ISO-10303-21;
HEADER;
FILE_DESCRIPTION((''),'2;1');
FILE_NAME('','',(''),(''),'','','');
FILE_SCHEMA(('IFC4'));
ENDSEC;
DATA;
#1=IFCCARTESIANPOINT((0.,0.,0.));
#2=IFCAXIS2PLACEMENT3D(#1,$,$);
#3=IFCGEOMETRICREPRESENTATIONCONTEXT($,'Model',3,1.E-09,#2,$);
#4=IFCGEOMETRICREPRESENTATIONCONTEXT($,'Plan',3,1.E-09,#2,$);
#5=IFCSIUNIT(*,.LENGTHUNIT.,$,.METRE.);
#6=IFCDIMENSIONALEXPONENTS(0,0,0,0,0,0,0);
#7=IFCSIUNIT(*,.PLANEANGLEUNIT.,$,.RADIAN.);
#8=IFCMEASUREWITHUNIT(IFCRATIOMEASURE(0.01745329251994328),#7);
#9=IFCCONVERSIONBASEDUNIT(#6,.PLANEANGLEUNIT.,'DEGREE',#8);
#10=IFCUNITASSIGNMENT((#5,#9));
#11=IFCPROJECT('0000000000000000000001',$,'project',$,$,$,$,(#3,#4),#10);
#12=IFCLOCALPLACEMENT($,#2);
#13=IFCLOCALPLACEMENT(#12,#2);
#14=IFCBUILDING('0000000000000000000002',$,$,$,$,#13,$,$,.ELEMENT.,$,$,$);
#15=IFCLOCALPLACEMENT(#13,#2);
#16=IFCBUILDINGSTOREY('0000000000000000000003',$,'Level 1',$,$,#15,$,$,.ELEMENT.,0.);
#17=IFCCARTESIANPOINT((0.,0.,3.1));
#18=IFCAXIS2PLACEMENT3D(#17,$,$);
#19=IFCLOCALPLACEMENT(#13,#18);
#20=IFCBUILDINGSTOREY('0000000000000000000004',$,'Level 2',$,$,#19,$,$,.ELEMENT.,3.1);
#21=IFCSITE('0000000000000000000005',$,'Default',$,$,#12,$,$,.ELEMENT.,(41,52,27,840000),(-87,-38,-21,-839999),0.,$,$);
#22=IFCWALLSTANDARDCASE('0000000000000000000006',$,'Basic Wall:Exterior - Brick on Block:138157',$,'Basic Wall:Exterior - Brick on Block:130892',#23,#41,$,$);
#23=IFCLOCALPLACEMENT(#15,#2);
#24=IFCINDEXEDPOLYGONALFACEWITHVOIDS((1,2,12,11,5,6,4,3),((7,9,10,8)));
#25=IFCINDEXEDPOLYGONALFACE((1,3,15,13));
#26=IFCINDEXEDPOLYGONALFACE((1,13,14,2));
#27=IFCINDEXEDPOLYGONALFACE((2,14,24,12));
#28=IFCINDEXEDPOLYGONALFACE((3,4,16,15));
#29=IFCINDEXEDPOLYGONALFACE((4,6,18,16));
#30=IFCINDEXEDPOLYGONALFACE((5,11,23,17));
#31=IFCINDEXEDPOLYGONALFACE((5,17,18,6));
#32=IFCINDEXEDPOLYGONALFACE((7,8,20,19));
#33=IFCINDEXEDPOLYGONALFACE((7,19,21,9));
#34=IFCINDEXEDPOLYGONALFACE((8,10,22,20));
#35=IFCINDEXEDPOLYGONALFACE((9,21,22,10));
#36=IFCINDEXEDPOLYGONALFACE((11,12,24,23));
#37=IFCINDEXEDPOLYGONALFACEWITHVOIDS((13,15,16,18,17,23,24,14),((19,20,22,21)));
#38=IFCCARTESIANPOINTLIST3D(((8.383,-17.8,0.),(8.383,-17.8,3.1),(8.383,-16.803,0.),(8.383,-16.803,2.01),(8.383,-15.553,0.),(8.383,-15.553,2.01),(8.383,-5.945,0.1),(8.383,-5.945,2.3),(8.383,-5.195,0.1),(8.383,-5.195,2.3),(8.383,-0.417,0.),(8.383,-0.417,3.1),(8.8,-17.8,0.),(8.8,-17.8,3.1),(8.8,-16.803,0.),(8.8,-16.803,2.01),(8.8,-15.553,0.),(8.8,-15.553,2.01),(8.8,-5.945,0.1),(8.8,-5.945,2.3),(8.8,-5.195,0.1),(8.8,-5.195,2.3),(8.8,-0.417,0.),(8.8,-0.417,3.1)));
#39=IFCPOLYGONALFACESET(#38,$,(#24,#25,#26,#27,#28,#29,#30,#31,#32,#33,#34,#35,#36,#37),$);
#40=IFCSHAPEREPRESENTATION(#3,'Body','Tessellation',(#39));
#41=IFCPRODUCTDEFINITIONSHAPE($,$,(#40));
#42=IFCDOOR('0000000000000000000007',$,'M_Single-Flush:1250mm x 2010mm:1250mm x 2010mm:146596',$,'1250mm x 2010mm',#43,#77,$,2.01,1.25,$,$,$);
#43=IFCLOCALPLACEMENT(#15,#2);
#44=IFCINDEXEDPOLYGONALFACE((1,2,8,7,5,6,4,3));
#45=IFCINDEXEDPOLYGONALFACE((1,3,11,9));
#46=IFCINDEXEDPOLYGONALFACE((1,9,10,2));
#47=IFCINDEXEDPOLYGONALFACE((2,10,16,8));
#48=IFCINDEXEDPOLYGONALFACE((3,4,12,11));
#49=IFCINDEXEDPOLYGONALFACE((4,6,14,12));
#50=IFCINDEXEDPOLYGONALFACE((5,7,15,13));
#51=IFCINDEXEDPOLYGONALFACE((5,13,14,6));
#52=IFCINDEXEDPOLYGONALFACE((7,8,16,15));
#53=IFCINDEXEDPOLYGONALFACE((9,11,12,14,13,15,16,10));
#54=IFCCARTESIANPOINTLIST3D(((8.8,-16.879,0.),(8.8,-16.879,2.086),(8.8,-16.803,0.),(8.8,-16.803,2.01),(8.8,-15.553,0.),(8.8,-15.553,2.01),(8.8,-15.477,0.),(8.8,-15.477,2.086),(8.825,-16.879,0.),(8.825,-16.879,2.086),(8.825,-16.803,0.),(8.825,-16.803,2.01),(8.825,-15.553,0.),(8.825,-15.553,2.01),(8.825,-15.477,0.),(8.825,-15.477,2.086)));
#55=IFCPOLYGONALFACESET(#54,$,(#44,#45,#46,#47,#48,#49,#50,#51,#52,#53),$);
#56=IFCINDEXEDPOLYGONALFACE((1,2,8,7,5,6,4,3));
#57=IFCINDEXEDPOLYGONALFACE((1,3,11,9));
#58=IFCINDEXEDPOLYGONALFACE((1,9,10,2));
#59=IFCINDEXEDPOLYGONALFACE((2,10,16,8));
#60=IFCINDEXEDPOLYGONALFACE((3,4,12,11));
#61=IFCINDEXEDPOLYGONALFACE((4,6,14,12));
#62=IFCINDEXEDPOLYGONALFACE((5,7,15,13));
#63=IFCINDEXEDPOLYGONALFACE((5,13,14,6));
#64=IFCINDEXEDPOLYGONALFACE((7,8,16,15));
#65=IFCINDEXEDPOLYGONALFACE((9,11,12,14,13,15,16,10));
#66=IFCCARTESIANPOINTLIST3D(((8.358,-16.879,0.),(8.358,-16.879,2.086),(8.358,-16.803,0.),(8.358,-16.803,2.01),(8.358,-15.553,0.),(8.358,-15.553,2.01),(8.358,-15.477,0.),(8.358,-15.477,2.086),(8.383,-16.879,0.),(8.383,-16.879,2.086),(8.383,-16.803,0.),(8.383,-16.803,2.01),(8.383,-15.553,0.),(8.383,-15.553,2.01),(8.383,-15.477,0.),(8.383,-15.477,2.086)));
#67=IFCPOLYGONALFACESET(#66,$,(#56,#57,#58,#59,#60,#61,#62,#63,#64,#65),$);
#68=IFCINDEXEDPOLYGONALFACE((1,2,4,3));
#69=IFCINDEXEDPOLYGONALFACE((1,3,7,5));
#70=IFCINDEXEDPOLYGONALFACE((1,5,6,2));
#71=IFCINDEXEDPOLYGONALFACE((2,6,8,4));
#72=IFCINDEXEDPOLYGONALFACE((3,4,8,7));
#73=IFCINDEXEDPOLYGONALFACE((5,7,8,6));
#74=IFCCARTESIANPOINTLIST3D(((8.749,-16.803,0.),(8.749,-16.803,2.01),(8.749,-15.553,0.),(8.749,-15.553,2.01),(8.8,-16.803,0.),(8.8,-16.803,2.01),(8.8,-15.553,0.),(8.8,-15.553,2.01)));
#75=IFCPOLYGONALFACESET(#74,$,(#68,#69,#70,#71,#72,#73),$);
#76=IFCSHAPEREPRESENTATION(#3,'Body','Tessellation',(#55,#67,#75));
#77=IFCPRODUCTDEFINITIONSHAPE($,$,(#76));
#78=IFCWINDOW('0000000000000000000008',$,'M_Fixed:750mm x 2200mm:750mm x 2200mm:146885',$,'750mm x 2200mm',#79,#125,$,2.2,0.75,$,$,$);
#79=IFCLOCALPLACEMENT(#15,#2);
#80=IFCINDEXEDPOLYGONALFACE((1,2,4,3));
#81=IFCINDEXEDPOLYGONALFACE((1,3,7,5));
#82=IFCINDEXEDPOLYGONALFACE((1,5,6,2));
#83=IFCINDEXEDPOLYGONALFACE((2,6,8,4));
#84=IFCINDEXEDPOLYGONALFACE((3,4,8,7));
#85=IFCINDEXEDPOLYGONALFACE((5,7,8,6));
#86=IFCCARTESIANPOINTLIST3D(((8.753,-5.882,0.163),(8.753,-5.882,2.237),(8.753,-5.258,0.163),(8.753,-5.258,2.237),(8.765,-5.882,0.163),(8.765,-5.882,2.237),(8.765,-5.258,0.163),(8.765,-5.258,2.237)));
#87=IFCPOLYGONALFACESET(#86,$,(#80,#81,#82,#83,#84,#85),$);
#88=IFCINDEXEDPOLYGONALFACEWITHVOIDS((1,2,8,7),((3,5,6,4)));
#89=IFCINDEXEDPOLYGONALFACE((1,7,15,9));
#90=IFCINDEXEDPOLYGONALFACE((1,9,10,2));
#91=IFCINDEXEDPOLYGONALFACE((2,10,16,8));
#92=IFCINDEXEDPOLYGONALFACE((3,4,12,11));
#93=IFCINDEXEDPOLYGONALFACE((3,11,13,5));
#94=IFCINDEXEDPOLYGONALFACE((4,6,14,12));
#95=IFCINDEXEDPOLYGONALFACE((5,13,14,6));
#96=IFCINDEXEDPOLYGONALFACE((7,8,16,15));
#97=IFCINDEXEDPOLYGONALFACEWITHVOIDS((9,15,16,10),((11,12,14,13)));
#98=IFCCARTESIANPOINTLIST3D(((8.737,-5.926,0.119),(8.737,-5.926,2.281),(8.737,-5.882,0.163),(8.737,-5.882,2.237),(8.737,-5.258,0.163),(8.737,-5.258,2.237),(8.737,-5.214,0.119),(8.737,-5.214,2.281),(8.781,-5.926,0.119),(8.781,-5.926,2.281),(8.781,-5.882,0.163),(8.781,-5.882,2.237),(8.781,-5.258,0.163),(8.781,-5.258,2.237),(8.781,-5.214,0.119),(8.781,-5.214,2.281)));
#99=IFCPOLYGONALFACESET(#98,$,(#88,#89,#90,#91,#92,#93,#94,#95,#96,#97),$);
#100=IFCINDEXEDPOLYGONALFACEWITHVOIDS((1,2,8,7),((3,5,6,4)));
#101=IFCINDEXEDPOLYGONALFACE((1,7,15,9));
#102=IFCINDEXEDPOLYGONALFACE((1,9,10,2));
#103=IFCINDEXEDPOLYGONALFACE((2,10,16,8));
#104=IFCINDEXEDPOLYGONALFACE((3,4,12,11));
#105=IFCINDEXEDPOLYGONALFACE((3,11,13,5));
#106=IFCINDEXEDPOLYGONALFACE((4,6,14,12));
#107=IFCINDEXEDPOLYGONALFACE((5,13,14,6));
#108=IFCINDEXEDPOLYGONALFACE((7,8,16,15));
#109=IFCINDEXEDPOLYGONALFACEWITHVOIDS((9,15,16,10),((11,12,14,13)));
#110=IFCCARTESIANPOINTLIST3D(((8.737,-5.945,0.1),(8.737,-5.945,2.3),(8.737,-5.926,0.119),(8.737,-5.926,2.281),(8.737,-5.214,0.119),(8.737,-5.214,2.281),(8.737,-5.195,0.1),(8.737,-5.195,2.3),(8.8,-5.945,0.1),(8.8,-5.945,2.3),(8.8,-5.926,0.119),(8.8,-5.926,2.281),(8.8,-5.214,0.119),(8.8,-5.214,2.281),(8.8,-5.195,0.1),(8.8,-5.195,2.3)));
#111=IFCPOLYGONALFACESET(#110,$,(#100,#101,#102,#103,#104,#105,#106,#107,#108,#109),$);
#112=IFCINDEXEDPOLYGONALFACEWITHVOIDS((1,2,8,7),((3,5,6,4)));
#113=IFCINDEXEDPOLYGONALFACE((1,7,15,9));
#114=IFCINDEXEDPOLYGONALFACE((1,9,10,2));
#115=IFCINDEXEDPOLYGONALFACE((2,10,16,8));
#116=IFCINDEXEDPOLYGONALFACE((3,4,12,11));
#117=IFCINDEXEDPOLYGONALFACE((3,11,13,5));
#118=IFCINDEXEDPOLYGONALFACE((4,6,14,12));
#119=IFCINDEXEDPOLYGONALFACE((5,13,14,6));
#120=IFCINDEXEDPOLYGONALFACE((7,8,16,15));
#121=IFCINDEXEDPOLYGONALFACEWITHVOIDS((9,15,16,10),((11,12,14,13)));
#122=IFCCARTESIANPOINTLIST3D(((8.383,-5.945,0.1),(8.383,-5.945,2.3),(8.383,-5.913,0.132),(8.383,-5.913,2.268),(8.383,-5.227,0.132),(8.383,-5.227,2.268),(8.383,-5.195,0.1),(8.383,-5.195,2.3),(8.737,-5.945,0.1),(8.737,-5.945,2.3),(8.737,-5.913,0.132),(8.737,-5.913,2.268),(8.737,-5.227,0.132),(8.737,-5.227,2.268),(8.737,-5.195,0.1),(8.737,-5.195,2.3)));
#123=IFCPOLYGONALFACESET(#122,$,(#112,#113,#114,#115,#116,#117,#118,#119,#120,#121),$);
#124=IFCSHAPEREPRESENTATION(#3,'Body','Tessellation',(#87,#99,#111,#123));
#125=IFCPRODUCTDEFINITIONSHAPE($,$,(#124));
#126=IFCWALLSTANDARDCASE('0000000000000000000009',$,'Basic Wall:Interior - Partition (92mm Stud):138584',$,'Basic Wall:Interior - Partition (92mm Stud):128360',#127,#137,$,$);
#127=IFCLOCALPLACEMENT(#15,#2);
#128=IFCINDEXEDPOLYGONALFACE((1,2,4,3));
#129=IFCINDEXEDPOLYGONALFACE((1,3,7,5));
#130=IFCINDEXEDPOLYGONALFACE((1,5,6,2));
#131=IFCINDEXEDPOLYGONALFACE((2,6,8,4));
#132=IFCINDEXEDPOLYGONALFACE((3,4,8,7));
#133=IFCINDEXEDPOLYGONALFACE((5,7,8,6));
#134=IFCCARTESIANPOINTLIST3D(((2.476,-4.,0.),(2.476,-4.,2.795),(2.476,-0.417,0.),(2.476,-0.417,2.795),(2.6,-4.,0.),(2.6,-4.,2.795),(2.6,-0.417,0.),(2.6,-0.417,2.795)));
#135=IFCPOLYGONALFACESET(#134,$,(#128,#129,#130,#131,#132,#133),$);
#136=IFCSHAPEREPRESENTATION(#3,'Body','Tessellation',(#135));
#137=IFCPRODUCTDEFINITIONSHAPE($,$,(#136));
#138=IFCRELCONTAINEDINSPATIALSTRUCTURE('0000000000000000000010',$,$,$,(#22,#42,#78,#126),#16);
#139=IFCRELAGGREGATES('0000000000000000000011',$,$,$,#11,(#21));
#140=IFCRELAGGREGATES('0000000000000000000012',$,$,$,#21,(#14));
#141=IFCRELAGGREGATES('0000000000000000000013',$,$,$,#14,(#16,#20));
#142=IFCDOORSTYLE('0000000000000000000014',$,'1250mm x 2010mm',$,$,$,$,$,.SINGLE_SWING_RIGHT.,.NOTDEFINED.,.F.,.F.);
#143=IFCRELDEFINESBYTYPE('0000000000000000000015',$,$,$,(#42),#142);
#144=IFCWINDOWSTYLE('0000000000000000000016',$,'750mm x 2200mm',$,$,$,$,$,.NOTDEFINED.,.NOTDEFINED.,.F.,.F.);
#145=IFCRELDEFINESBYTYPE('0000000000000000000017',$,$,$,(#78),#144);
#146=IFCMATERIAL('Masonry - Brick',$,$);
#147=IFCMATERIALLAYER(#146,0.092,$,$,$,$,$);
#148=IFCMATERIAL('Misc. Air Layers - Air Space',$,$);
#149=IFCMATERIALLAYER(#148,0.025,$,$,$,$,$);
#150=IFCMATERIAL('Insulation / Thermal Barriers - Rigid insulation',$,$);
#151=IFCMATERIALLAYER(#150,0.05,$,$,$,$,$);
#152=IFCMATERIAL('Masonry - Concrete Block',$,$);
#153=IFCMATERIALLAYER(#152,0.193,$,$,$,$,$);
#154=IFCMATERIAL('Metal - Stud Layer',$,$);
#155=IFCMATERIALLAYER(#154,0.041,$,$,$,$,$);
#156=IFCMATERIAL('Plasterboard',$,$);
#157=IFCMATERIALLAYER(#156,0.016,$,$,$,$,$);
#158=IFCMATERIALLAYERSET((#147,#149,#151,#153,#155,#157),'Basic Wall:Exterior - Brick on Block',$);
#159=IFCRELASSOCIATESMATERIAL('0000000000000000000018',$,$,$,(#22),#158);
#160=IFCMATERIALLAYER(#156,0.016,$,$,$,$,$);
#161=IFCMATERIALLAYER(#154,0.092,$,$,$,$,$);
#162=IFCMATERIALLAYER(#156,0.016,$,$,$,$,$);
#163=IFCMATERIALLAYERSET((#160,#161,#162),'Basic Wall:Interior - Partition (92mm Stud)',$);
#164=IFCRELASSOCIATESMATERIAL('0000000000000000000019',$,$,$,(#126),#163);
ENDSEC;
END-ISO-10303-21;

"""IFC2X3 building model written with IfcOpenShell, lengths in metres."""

from ifc_helpers import new_model, entity, si_unit, converted_unit, frame, frame_2d, origin, origin_2d_with_axis, place, context, project, spatial, polyline, rectangle, outline, extrude, source, transform, mapped, material, layer, layer_set, layer_usage, type_object, type_shapes, element, fill, save


model = new_model("IFC2X3")

# Units and contexts
model_context = context("Model", 3, precision=1e-09, world=origin())
plan_context = context("Plan", 3, precision=1e-09, world=origin())
ifc_project = project(units=[si_unit("LENGTHUNIT", "METRE"), converted_unit("PLANEANGLEUNIT", "DEGREE", entity("IfcRatioMeasure", 0.01745329251994328), si_unit("PLANEANGLEUNIT", "RADIAN"), dimensions=[0, 0, 0, 0, 0, 0, 0])], contexts=[model_context, plan_context])

# Site, building, storey
site_placement = place(None, origin())
site = spatial("IfcSite", under=ifc_project, at=site_placement, Name="Default", CompositionType="ELEMENT", RefLatitude=(41, 52, 27, 840000), RefLongitude=(-87, -38, -21, -839999), RefElevation=0.0)
building_placement = place(site_placement, origin())
building = spatial("IfcBuilding", under=site, at=building_placement, CompositionType="ELEMENT")
storey_1_placement = place(building_placement, origin())
storey_1 = spatial("IfcBuildingStorey", under=building, at=storey_1_placement, Name="Level 1", CompositionType="ELEMENT", Elevation=0.0)

# Shared definitions
ifc_material_1 = material(Name="Masonry - Brick")
ifc_layer_1 = layer(ifc_material_1, 0.092)
ifc_material_2 = material(Name="Misc. Air Layers - Air Space")
ifc_layer_2 = layer(ifc_material_2, 0.025)
ifc_material_3 = material(Name="Insulation / Thermal Barriers - Rigid insulation")
ifc_layer_3 = layer(ifc_material_3, 0.05)
ifc_material_4 = material(Name="Masonry - Concrete Block")
ifc_layer_4 = layer(ifc_material_4, 0.193)
ifc_material_5 = material(Name="Metal - Stud Layer")
ifc_layer_5 = layer(ifc_material_5, 0.041)
ifc_material_6 = material(Name="Plasterboard")
ifc_layer_6 = layer(ifc_material_6, 0.016)
ifc_layer_set_1 = layer_set([ifc_layer_1, ifc_layer_2, ifc_layer_3, ifc_layer_4, ifc_layer_5, ifc_layer_6], Name="Basic Wall:Exterior - Brick on Block")

# Wall, openings, door, window
ifc_layer_usage_1 = layer_usage(ifc_layer_set_1, "AXIS2", "NEGATIVE", 0.2085)
wall_1_placement = place(storey_1_placement, frame((8.5915, -0.417, 0.0), z_axis=(0.0, 0.0, 1.0), x_axis=(0.0, -1.0, 0.0)))
wall_1 = element("IfcWallStandardCase", 1, at=wall_1_placement, inside=storey_1, material=ifc_layer_usage_1, Name="Basic Wall:Exterior - Brick on Block:138157", ObjectType="Basic Wall:Exterior - Brick on Block:130892", context=model_context, shape_type="SweptSolid", body=[
    extrude(rectangle(XDim=17.383, YDim=0.417, at=frame_2d((8.6915, 0.0), x_axis=(-1.0, 0.0))), origin(), (0.0, 0.0, 1.0), 3.1),
])
opening_1_placement = place(wall_1_placement, frame((15.136, -0.2085, 0.0)))
opening_1 = element("IfcOpeningElement", 2, at=opening_1_placement, cuts=wall_1, ObjectType="Opening", context=model_context, shape_type="SweptSolid", body=[
    extrude(rectangle(XDim=1.25, YDim=2.01, at=frame_2d((1.005, 0.625), x_axis=(0.0, 1.0))), frame((0.0, 0.0, 0.0), z_axis=(0.0, 1.0, 0.0), x_axis=(0.0, 0.0, 1.0)), (0.0, 0.0, 1.0), 0.417),
])
opening_2_placement = place(wall_1_placement, frame((4.778, -0.2085, 0.1)))
opening_2 = element("IfcOpeningElement", 3, at=opening_2_placement, cuts=wall_1, ObjectType="Opening", context=model_context, shape_type="SweptSolid", body=[
    extrude(rectangle(XDim=2.2, YDim=0.75, at=frame_2d((1.1, 0.375), x_axis=(1.0, 0.0))), frame((0.0, 0.0, 0.0), z_axis=(0.0, 1.0, 0.0), x_axis=(0.0, 0.0, 1.0)), (0.0, 0.0, 1.0), 0.417),
])
door_style_1 = type_object("IfcDoorStyle", Name="1250mm x 2010mm", ConstructionType="NOTDEFINED", OperationType="SINGLE_SWING_RIGHT", ParameterTakesPrecedence=False, Sizeable=False)
shared_shape_1 = source(origin(), model_context, "Body", "SweptSolid", [
    extrude(outline(polyline([(-0.701, -1.062), (0.701, -1.062), (0.701, 1.024), (0.625, 1.024), (0.625, -0.986), (-0.625, -0.986), (-0.625, 1.024), (-0.701, 1.024), (-0.701, -1.062)])), frame((0.625, 0.417, 1.024), z_axis=(0.0, 1.0, 0.0), x_axis=(1.0, 0.0, 0.0)), (0.0, 0.0, 1.0), 0.025),
    extrude(outline(polyline([(-1.062, -0.701), (1.024, -0.701), (1.024, -0.625), (-0.986, -0.625), (-0.986, 0.625), (1.024, 0.625), (1.024, 0.701), (-1.062, 0.701), (-1.062, -0.701)])), frame((0.625, -0.025, 1.024), z_axis=(0.0, 1.0, 0.0), x_axis=(0.0, 0.0, -1.0)), (0.0, 0.0, 1.0), 0.025),
    extrude(rectangle(XDim=0.051, YDim=1.25, at=origin_2d_with_axis()), frame((0.625, 0.3915, 0.0), z_axis=(0.0, 0.0, 1.0), x_axis=(0.0, 1.0, 0.0)), (0.0, 0.0, 1.0), 2.01),
])
type_shapes(door_style_1, [shared_shape_1])
door_1_placement = place(opening_1_placement, origin())
door_1 = element("IfcDoor", 4, at=door_1_placement, inside=storey_1, type_object=door_style_1, Name="M_Single-Flush:1250mm x 2010mm:1250mm x 2010mm:146596", ObjectType="1250mm x 2010mm", OverallHeight=2.01, OverallWidth=1.25, context=model_context, shape_type="MappedRepresentation", body=[
    mapped(shared_shape_1, transform((0.0, 0.0, 0.0), scale=1.0)),
])
fill(opening_1, door_1)
window_style_1 = type_object("IfcWindowStyle", Name="750mm x 2200mm", ConstructionType="NOTDEFINED", OperationType="NOTDEFINED", ParameterTakesPrecedence=False, Sizeable=False)
shared_shape_2 = source(origin(), model_context, "Body", "SweptSolid", [
    extrude(rectangle(XDim=0.012, YDim=0.624, at=origin_2d_with_axis()), frame((0.375, 0.376, 0.063), z_axis=(0.0, 0.0, 1.0), x_axis=(0.0, -1.0, 0.0)), (0.0, 0.0, 1.0), 2.074),
    extrude(outline(polyline([(-0.356, -1.081), (0.356, -1.081), (0.356, 1.081), (-0.356, 1.081), (-0.356, -1.081)]), holes=[polyline([(-0.312, -1.037), (-0.312, 1.037), (0.312, 1.037), (0.312, -1.037), (-0.312, -1.037)])]), frame((0.375, 0.354, 1.1), z_axis=(0.0, 1.0, 0.0), x_axis=(1.0, 0.0, 0.0)), (0.0, 0.0, 1.0), 0.044),
    extrude(outline(polyline([(-0.375, -1.1), (0.375, -1.1), (0.375, 1.1), (-0.375, 1.1), (-0.375, -1.1)]), holes=[polyline([(-0.356, -1.081), (-0.356, 1.081), (0.356, 1.081), (0.356, -1.081), (-0.356, -1.081)])]), frame((0.375, 0.354, 1.1), z_axis=(0.0, 1.0, 0.0), x_axis=(1.0, 0.0, 0.0)), (0.0, 0.0, 1.0), 0.063),
    extrude(outline(polyline([(-0.375, -1.1), (0.375, -1.1), (0.375, 1.1), (-0.375, 1.1), (-0.375, -1.1)]), holes=[polyline([(-0.343, -1.068), (-0.343, 1.068), (0.343, 1.068), (0.343, -1.068), (-0.343, -1.068)])]), frame((0.375, 0.0, 1.1), z_axis=(0.0, 1.0, 0.0), x_axis=(1.0, 0.0, 0.0)), (0.0, 0.0, 1.0), 0.354),
])
type_shapes(window_style_1, [shared_shape_2])
window_1_placement = place(opening_2_placement, origin())
window_1 = element("IfcWindow", 5, at=window_1_placement, inside=storey_1, type_object=window_style_1, Name="M_Fixed:750mm x 2200mm:750mm x 2200mm:146885", ObjectType="750mm x 2200mm", OverallHeight=2.2, OverallWidth=0.75, context=model_context, shape_type="MappedRepresentation", body=[
    mapped(shared_shape_2, transform((0.0, 0.0, 0.0), scale=1.0)),
])
fill(opening_2, window_1)

# Wall
ifc_layer_7 = layer(ifc_material_6, 0.016)
ifc_layer_8 = layer(ifc_material_5, 0.092)
ifc_layer_9 = layer(ifc_material_6, 0.016)
ifc_layer_set_2 = layer_set([ifc_layer_7, ifc_layer_8, ifc_layer_9], Name="Basic Wall:Interior - Partition (92mm Stud)")
ifc_layer_usage_2 = layer_usage(ifc_layer_set_2, "AXIS2", "NEGATIVE", 0.062)
wall_2_placement = place(storey_1_placement, frame((2.538, -0.417, 0.0), z_axis=(0.0, 0.0, 1.0), x_axis=(0.0, -1.0, 0.0)))
element("IfcWallStandardCase", 6, at=wall_2_placement, inside=storey_1, material=ifc_layer_usage_2, Name="Basic Wall:Interior - Partition (92mm Stud):138584", ObjectType="Basic Wall:Interior - Partition (92mm Stud):128360", context=model_context, shape_type="SweptSolid", body=[
    extrude(rectangle(XDim=3.583, YDim=0.124, at=frame_2d((1.7915, 0.0), x_axis=(-1.0, 0.0))), origin(), (0.0, 0.0, 1.0), 2.795),
])

# Shared definitions
storey_2_placement = place(building_placement, frame((0.0, 0.0, 3.1)))
storey_2 = spatial("IfcBuildingStorey", under=building, at=storey_2_placement, Name="Level 2", CompositionType="ELEMENT", Elevation=3.1)

save(model, "model.ifc")
